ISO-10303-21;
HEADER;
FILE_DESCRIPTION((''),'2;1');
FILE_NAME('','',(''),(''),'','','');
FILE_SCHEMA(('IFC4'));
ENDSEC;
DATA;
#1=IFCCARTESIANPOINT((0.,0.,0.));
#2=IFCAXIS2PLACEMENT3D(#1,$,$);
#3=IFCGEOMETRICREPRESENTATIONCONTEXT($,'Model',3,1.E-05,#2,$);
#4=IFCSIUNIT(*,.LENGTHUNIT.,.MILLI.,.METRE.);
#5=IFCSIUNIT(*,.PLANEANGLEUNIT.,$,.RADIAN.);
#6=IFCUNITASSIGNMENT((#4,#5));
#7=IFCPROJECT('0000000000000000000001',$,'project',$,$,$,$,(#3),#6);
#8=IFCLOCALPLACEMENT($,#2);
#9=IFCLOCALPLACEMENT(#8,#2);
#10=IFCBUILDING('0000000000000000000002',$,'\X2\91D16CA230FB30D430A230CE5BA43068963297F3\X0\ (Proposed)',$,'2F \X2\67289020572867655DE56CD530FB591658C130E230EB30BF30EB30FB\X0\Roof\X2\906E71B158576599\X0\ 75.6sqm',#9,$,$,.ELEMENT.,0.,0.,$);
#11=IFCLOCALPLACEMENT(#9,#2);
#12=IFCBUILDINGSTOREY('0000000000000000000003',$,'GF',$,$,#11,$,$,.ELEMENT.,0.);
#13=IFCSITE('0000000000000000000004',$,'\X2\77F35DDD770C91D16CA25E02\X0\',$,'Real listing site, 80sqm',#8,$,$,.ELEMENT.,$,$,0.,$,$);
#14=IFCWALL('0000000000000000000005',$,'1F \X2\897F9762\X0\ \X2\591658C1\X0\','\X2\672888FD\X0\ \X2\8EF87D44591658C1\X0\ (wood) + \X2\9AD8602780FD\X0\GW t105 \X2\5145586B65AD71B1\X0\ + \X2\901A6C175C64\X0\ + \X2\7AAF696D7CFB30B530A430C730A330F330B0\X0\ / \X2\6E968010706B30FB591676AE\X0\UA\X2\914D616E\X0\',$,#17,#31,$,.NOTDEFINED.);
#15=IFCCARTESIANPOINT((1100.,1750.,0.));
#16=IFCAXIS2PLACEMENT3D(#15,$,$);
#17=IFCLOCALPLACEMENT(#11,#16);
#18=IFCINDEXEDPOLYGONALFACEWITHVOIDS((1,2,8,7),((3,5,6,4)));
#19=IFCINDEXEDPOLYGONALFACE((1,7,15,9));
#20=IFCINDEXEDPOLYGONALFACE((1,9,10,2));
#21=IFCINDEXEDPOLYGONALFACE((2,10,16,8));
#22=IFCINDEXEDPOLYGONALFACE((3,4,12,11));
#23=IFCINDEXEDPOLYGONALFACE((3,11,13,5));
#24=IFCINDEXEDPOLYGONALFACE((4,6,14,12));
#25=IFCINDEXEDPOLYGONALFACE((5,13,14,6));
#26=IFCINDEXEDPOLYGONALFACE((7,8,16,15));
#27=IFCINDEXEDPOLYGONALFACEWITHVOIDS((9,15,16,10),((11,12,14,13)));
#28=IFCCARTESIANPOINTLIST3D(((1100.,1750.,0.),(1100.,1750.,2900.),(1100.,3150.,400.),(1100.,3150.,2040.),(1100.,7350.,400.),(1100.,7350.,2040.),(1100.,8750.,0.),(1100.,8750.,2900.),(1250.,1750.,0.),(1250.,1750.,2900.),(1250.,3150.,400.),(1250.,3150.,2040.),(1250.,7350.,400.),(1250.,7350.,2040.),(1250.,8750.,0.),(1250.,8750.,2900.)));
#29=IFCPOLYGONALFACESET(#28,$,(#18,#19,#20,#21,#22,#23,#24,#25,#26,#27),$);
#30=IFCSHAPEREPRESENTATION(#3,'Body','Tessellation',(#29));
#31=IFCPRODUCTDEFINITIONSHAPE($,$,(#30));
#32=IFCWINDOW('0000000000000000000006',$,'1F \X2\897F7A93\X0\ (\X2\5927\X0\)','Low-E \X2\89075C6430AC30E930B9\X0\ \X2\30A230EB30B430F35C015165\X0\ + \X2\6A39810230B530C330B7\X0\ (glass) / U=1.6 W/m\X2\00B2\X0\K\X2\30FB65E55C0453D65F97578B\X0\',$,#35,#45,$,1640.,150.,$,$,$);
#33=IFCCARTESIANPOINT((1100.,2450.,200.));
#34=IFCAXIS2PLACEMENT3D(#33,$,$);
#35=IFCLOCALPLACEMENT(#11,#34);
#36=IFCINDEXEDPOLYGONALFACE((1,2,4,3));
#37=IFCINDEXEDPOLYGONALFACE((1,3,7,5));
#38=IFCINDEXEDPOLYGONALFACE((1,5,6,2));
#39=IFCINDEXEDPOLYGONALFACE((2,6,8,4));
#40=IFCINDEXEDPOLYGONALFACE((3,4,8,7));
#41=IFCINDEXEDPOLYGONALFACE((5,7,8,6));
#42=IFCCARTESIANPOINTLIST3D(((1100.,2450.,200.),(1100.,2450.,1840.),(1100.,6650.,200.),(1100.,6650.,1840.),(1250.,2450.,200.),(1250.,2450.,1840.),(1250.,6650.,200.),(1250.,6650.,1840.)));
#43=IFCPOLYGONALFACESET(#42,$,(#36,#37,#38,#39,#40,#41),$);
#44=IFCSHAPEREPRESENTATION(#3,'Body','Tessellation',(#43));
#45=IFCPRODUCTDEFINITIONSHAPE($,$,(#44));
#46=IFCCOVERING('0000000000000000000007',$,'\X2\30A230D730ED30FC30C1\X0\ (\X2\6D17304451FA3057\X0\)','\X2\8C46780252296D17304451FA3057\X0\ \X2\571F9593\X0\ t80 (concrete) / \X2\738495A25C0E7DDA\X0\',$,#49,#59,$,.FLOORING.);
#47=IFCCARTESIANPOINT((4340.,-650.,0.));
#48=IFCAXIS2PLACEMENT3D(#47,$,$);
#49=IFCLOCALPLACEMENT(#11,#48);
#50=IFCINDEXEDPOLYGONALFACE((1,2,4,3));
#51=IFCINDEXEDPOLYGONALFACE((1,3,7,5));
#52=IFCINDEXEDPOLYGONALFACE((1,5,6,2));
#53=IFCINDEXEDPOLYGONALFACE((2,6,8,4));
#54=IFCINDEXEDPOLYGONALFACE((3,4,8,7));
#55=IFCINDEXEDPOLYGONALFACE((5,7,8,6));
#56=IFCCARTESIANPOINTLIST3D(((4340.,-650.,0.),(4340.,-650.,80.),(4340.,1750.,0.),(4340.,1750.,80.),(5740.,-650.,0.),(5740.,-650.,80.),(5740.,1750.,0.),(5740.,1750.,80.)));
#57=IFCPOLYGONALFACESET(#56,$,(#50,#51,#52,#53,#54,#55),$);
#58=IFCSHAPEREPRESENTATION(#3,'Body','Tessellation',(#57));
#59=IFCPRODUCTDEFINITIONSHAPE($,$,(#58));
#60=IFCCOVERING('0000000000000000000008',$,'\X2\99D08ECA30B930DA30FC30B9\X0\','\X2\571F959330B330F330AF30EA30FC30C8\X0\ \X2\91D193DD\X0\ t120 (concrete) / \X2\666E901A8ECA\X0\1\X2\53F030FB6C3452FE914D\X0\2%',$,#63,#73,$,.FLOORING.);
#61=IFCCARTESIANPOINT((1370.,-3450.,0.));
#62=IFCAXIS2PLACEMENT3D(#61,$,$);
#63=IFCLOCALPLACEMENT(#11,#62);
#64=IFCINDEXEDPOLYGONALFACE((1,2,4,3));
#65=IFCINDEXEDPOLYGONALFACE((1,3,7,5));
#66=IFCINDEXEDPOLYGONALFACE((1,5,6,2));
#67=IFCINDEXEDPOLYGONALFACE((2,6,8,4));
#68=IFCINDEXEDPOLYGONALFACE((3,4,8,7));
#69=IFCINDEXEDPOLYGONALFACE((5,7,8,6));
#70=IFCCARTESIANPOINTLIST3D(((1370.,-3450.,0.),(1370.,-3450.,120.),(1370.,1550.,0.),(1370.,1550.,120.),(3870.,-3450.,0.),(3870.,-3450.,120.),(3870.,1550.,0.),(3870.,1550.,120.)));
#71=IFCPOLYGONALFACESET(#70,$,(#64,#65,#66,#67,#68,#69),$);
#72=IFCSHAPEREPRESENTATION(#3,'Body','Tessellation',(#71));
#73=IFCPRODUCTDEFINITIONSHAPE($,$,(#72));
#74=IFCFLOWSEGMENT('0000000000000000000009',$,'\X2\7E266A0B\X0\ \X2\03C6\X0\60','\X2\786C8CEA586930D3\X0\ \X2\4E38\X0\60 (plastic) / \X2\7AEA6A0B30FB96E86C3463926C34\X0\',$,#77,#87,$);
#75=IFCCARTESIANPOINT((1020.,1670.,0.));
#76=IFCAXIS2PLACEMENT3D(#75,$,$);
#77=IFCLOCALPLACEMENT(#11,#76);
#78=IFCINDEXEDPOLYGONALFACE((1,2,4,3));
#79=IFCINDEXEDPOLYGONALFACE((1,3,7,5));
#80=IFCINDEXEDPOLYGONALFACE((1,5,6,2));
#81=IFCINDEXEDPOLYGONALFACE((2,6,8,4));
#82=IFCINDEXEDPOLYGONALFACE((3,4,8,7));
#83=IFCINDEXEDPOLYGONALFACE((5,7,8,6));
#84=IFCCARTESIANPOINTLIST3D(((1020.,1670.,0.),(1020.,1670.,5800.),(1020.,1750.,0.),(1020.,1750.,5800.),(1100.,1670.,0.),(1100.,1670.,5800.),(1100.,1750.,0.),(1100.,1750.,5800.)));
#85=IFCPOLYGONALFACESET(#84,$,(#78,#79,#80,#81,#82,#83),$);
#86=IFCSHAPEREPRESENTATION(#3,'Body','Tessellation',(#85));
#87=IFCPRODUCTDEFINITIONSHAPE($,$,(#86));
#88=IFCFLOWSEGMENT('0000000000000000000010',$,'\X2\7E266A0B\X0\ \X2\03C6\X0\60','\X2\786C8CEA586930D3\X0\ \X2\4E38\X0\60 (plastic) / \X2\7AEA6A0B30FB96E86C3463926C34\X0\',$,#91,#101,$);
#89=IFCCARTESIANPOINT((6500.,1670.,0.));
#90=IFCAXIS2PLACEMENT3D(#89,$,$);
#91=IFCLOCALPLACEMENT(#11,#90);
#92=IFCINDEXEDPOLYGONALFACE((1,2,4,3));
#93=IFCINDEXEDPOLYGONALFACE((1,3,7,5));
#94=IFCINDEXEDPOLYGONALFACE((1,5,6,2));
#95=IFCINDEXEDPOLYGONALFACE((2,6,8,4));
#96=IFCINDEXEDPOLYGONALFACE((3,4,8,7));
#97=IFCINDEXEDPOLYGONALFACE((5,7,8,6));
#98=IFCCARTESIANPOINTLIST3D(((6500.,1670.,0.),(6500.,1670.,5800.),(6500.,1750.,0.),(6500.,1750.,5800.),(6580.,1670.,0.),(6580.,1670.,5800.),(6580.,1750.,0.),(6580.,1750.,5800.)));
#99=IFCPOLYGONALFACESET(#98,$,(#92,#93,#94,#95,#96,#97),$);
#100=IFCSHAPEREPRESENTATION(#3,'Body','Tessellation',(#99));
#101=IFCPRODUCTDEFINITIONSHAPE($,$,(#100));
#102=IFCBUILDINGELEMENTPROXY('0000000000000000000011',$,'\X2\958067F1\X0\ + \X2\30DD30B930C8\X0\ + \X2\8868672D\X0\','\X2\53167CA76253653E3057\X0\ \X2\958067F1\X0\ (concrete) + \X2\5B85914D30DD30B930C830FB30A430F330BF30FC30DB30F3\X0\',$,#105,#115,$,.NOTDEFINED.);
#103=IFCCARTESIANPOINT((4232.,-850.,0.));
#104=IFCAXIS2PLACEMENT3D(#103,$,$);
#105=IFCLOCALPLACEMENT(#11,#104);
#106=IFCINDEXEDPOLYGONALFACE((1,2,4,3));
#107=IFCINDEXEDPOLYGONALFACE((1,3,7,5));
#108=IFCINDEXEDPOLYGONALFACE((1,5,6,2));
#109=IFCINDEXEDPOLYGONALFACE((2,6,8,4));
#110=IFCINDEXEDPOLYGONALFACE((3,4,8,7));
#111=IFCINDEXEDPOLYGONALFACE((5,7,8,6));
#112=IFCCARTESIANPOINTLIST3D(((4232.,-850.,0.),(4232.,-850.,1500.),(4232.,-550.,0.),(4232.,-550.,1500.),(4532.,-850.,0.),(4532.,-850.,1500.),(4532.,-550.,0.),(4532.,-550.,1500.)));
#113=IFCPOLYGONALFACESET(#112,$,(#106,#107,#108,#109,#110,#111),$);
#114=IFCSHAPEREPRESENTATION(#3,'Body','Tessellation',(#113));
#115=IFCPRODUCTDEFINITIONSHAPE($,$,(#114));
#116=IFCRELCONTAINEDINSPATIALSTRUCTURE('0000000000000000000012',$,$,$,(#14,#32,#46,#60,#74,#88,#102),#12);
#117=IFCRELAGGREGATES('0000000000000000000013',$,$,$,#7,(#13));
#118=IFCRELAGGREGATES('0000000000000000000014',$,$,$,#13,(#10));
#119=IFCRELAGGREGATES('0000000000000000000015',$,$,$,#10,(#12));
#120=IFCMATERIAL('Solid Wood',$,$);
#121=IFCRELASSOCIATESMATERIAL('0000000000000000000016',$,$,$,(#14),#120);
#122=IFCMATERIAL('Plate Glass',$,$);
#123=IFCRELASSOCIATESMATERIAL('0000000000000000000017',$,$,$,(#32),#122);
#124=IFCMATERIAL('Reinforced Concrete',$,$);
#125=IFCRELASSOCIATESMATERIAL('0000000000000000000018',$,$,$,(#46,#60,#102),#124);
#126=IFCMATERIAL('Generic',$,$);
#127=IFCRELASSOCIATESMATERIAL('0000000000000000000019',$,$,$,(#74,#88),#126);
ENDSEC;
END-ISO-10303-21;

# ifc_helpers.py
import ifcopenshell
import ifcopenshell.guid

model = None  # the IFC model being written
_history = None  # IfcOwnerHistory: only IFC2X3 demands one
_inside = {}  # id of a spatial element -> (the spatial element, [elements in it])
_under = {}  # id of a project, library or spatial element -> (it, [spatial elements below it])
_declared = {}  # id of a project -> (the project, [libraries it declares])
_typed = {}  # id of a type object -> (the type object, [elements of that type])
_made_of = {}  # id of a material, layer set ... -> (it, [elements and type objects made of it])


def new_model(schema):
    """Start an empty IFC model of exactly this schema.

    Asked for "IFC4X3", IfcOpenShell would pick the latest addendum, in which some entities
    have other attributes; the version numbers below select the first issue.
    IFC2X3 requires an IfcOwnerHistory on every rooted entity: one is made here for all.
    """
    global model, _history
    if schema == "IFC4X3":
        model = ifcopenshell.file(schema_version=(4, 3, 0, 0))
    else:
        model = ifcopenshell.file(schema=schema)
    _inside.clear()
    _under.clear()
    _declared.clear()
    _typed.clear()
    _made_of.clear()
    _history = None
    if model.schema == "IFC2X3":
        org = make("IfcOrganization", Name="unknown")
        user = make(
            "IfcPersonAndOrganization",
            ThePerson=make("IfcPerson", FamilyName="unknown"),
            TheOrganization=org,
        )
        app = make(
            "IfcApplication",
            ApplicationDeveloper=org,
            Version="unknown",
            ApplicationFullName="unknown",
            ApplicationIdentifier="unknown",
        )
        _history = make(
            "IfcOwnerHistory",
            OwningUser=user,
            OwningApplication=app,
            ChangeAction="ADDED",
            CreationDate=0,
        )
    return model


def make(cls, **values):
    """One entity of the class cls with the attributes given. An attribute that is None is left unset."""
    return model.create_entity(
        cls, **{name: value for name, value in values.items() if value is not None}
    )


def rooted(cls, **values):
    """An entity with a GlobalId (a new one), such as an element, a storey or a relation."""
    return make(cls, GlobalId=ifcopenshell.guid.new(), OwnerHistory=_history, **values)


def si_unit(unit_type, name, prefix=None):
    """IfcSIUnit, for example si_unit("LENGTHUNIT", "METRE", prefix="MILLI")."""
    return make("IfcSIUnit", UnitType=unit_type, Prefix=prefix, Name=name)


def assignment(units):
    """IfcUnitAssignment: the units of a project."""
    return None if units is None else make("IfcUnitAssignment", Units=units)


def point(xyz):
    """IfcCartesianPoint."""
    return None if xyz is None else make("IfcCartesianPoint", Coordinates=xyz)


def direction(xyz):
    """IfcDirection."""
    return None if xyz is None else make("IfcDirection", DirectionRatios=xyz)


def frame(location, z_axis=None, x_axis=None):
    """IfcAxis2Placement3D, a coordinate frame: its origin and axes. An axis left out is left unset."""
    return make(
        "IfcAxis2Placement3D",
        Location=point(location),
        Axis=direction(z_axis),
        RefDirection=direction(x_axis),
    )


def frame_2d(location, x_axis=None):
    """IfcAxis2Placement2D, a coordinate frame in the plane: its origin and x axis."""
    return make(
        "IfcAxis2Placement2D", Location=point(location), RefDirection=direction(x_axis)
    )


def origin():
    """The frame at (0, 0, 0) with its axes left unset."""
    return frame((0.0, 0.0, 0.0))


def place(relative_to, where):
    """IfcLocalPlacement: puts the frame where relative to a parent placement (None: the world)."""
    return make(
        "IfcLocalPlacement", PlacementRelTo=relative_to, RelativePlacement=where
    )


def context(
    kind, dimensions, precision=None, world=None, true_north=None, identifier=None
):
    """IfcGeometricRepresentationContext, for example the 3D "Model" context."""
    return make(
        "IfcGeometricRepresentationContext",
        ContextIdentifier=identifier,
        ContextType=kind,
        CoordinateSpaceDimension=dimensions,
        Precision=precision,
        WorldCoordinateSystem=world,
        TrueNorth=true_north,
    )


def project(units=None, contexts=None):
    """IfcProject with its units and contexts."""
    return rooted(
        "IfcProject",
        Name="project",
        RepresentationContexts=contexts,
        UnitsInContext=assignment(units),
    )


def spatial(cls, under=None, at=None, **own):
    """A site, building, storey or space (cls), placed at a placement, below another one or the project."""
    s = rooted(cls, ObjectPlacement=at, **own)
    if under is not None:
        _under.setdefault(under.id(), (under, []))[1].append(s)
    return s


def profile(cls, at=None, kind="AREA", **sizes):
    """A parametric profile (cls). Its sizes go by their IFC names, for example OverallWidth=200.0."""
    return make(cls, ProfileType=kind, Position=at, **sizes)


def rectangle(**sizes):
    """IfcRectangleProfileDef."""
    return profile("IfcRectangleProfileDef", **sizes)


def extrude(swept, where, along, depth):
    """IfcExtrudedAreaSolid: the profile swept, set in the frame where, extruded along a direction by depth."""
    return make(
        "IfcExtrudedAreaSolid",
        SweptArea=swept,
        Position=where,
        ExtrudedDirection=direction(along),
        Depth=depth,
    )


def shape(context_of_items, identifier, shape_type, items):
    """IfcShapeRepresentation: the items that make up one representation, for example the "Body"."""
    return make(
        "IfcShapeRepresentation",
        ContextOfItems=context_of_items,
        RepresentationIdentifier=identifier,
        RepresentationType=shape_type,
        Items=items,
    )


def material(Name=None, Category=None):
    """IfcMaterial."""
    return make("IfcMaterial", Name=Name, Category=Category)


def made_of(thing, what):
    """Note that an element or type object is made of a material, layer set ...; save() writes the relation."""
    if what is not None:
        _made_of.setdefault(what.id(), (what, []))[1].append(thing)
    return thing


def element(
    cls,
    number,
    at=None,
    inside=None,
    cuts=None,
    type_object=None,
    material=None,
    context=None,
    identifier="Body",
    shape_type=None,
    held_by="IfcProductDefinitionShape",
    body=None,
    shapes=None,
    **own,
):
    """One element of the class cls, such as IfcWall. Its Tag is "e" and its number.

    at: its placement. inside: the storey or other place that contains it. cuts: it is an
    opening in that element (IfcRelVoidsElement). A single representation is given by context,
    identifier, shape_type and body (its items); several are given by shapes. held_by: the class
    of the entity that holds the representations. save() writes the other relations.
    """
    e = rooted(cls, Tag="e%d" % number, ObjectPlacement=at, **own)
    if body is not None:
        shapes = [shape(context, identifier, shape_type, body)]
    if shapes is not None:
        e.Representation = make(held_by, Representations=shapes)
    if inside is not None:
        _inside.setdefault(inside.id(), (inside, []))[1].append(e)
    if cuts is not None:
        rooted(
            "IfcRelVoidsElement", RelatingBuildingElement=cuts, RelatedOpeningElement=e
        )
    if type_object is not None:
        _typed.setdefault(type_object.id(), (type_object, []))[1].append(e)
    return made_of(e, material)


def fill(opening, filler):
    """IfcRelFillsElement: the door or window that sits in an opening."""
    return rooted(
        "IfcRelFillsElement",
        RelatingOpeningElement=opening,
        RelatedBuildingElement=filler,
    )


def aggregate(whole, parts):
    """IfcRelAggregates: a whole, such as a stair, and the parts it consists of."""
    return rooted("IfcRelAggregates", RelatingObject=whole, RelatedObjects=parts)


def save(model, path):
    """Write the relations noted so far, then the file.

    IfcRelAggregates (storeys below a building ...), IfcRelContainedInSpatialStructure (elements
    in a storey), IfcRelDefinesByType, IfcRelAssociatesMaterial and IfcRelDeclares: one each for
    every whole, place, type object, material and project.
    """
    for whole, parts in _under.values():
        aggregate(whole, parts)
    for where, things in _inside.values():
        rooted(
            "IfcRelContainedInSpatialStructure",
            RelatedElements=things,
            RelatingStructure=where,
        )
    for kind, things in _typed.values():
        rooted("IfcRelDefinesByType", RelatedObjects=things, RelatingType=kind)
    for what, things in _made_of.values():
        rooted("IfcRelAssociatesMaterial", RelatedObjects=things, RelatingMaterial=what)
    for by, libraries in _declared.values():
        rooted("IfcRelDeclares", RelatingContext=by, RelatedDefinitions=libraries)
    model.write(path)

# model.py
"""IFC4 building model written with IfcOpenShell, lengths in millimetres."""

from ifc_helpers import new_model, si_unit, frame, frame_2d, origin, place, context, project, spatial, rectangle, extrude, material, element, fill, save


model = new_model("IFC4")

# Units and contexts
model_context = context("Model", 3, precision=1e-05, world=origin())
ifc_project = project(units=[si_unit("LENGTHUNIT", "METRE", prefix="MILLI"), si_unit("PLANEANGLEUNIT", "RADIAN")], contexts=[model_context])

# Site, building, storey
site_placement = place(None, origin())
site = spatial("IfcSite", under=ifc_project, at=site_placement, Name="石川県金沢市", ObjectType="Real listing site, 80sqm", CompositionType="ELEMENT", RefElevation=0.0)
building_placement = place(site_placement, origin())
building = spatial("IfcBuilding", under=site, at=building_placement, Name="金沢・ピアノ室と防音 (Proposed)", ObjectType="2F 木造在来工法・外壁モルタル・Roof遮熱塗料 75.6sqm", CompositionType="ELEMENT", ElevationOfRefHeight=0.0, ElevationOfTerrain=0.0)
storey_placement = place(building_placement, origin())
storey = spatial("IfcBuildingStorey", under=building, at=storey_placement, Name="GF", CompositionType="ELEMENT", Elevation=0.0)

# Shared definitions
ifc_material_1 = material(Name="Solid Wood")

# Shared definitions
ifc_material_2 = material(Name="Reinforced Concrete")

# Shared definitions
ifc_material_3 = material(Name="Plate Glass")

# Wall, opening, window
wall_1_placement = place(storey_placement, frame((1100.0, 1750.0, 0.0)))
wall_1 = element("IfcWall", 1, at=wall_1_placement, inside=storey, material=ifc_material_1, Name="1F 西面 外壁", Description="木製 軸組外壁 (wood) + 高性能GW t105 充填断熱 + 通気層 + 窯業系サイディング / 準耐火・外皮UA配慮", PredefinedType="NOTDEFINED", context=model_context, shape_type="SweptSolid", body=[
    extrude(rectangle(XDim=150.0, YDim=7000.0, at=frame_2d((75.0, 3500.0))), frame((1100.0, 1750.0, 0.0)), (0.0, 0.0, 1.0), 2900.0),
])
opening_1_placement = place(storey_placement, frame((1100.0, 2450.0, 200.0)))
opening_1 = element("IfcOpeningElement", 2, at=opening_1_placement, cuts=wall_1, PredefinedType="NOTDEFINED", context=model_context, shape_type="SweptSolid", body=[
    extrude(rectangle(XDim=150.0, YDim=4200.0, at=frame_2d((75.0, 2100.0))), frame((1100.0, 2450.0, 200.0)), (0.0, 0.0, 1.0), 1640.0),
])
window_1_placement = place(storey_placement, frame((1100.0, 2450.0, 200.0)))
window_1 = element("IfcWindow", 3, at=window_1_placement, inside=storey, material=ifc_material_3, Name="1F 西窓 (大)", Description="Low-E 複層ガラス アルゴン封入 + 樹脂サッシ (glass) / U=1.6 W/m²K・日射取得型", OverallHeight=1640.0, OverallWidth=150.0, context=model_context, shape_type="SweptSolid", body=[
    extrude(rectangle(XDim=150.0, YDim=4200.0, at=frame_2d((75.0, 2100.0))), frame((1100.0, 2450.0, 200.0)), (0.0, 0.0, 1.0), 1640.0),
])
fill(opening_1, window_1)

# Coverings
covering_1_placement = place(storey_placement, frame((4340.0, -650.0, 0.0)))
element("IfcCovering", 4, at=covering_1_placement, inside=storey, material=ifc_material_2, Name="アプローチ (洗い出し)", Description="豆砂利洗い出し 土間 t80 (concrete) / 玄関導線", PredefinedType="FLOORING", context=model_context, shape_type="SweptSolid", body=[
    extrude(rectangle(XDim=1400.0, YDim=2400.0, at=frame_2d((700.0, 1200.0))), frame((4340.0, -650.0, 0.0)), (0.0, 0.0, 1.0), 80.0),
])
covering_2_placement = place(storey_placement, frame((1370.0, -3450.0, 0.0)))
element("IfcCovering", 5, at=covering_2_placement, inside=storey, material=ifc_material_2, Name="駐車スペース", Description="土間コンクリート 金鏝 t120 (concrete) / 普通車1台・水勾配2%", PredefinedType="FLOORING", context=model_context, shape_type="SweptSolid", body=[
    extrude(rectangle(XDim=2500.0, YDim=5000.0, at=frame_2d((1250.0, 2500.0))), frame((1370.0, -3450.0, 0.0)), (0.0, 0.0, 1.0), 120.0),
])

# Flow segments
ifc_material_4 = material(Name="Generic")
flow_segment_1_placement = place(storey_placement, frame((1020.0, 1670.0, 0.0)))
element("IfcFlowSegment", 6, at=flow_segment_1_placement, inside=storey, material=ifc_material_4, Name="縦樋 φ60", Description="硬質塩ビ 丸60 (plastic) / 竪樋・雨水排水", context=model_context, shape_type="SweptSolid", body=[
    extrude(rectangle(XDim=80.0, YDim=80.0, at=frame_2d((40.0, 40.0))), frame((1020.0, 1670.0, 0.0)), (0.0, 0.0, 1.0), 5800.0),
])
flow_segment_2_placement = place(storey_placement, frame((6500.0, 1670.0, 0.0)))
element("IfcFlowSegment", 7, at=flow_segment_2_placement, inside=storey, material=ifc_material_4, Name="縦樋 φ60", Description="硬質塩ビ 丸60 (plastic) / 竪樋・雨水排水", context=model_context, shape_type="SweptSolid", body=[
    extrude(rectangle(XDim=80.0, YDim=80.0, at=frame_2d((40.0, 40.0))), frame((6500.0, 1670.0, 0.0)), (0.0, 0.0, 1.0), 5800.0),
])

# Building element proxy
proxy_placement = place(storey_placement, frame((4232.0, -850.0, 0.0)))
element("IfcBuildingElementProxy", 8, at=proxy_placement, inside=storey, material=ifc_material_2, Name="門柱 + ポスト + 表札", Description="化粧打放し 門柱 (concrete) + 宅配ポスト・インターホン", PredefinedType="NOTDEFINED", context=model_context, shape_type="SweptSolid", body=[
    extrude(rectangle(XDim=300.0, YDim=300.0, at=frame_2d((150.0, 150.0))), frame((4232.0, -850.0, 0.0)), (0.0, 0.0, 1.0), 1500.0),
])

save(model, "model.ifc")
